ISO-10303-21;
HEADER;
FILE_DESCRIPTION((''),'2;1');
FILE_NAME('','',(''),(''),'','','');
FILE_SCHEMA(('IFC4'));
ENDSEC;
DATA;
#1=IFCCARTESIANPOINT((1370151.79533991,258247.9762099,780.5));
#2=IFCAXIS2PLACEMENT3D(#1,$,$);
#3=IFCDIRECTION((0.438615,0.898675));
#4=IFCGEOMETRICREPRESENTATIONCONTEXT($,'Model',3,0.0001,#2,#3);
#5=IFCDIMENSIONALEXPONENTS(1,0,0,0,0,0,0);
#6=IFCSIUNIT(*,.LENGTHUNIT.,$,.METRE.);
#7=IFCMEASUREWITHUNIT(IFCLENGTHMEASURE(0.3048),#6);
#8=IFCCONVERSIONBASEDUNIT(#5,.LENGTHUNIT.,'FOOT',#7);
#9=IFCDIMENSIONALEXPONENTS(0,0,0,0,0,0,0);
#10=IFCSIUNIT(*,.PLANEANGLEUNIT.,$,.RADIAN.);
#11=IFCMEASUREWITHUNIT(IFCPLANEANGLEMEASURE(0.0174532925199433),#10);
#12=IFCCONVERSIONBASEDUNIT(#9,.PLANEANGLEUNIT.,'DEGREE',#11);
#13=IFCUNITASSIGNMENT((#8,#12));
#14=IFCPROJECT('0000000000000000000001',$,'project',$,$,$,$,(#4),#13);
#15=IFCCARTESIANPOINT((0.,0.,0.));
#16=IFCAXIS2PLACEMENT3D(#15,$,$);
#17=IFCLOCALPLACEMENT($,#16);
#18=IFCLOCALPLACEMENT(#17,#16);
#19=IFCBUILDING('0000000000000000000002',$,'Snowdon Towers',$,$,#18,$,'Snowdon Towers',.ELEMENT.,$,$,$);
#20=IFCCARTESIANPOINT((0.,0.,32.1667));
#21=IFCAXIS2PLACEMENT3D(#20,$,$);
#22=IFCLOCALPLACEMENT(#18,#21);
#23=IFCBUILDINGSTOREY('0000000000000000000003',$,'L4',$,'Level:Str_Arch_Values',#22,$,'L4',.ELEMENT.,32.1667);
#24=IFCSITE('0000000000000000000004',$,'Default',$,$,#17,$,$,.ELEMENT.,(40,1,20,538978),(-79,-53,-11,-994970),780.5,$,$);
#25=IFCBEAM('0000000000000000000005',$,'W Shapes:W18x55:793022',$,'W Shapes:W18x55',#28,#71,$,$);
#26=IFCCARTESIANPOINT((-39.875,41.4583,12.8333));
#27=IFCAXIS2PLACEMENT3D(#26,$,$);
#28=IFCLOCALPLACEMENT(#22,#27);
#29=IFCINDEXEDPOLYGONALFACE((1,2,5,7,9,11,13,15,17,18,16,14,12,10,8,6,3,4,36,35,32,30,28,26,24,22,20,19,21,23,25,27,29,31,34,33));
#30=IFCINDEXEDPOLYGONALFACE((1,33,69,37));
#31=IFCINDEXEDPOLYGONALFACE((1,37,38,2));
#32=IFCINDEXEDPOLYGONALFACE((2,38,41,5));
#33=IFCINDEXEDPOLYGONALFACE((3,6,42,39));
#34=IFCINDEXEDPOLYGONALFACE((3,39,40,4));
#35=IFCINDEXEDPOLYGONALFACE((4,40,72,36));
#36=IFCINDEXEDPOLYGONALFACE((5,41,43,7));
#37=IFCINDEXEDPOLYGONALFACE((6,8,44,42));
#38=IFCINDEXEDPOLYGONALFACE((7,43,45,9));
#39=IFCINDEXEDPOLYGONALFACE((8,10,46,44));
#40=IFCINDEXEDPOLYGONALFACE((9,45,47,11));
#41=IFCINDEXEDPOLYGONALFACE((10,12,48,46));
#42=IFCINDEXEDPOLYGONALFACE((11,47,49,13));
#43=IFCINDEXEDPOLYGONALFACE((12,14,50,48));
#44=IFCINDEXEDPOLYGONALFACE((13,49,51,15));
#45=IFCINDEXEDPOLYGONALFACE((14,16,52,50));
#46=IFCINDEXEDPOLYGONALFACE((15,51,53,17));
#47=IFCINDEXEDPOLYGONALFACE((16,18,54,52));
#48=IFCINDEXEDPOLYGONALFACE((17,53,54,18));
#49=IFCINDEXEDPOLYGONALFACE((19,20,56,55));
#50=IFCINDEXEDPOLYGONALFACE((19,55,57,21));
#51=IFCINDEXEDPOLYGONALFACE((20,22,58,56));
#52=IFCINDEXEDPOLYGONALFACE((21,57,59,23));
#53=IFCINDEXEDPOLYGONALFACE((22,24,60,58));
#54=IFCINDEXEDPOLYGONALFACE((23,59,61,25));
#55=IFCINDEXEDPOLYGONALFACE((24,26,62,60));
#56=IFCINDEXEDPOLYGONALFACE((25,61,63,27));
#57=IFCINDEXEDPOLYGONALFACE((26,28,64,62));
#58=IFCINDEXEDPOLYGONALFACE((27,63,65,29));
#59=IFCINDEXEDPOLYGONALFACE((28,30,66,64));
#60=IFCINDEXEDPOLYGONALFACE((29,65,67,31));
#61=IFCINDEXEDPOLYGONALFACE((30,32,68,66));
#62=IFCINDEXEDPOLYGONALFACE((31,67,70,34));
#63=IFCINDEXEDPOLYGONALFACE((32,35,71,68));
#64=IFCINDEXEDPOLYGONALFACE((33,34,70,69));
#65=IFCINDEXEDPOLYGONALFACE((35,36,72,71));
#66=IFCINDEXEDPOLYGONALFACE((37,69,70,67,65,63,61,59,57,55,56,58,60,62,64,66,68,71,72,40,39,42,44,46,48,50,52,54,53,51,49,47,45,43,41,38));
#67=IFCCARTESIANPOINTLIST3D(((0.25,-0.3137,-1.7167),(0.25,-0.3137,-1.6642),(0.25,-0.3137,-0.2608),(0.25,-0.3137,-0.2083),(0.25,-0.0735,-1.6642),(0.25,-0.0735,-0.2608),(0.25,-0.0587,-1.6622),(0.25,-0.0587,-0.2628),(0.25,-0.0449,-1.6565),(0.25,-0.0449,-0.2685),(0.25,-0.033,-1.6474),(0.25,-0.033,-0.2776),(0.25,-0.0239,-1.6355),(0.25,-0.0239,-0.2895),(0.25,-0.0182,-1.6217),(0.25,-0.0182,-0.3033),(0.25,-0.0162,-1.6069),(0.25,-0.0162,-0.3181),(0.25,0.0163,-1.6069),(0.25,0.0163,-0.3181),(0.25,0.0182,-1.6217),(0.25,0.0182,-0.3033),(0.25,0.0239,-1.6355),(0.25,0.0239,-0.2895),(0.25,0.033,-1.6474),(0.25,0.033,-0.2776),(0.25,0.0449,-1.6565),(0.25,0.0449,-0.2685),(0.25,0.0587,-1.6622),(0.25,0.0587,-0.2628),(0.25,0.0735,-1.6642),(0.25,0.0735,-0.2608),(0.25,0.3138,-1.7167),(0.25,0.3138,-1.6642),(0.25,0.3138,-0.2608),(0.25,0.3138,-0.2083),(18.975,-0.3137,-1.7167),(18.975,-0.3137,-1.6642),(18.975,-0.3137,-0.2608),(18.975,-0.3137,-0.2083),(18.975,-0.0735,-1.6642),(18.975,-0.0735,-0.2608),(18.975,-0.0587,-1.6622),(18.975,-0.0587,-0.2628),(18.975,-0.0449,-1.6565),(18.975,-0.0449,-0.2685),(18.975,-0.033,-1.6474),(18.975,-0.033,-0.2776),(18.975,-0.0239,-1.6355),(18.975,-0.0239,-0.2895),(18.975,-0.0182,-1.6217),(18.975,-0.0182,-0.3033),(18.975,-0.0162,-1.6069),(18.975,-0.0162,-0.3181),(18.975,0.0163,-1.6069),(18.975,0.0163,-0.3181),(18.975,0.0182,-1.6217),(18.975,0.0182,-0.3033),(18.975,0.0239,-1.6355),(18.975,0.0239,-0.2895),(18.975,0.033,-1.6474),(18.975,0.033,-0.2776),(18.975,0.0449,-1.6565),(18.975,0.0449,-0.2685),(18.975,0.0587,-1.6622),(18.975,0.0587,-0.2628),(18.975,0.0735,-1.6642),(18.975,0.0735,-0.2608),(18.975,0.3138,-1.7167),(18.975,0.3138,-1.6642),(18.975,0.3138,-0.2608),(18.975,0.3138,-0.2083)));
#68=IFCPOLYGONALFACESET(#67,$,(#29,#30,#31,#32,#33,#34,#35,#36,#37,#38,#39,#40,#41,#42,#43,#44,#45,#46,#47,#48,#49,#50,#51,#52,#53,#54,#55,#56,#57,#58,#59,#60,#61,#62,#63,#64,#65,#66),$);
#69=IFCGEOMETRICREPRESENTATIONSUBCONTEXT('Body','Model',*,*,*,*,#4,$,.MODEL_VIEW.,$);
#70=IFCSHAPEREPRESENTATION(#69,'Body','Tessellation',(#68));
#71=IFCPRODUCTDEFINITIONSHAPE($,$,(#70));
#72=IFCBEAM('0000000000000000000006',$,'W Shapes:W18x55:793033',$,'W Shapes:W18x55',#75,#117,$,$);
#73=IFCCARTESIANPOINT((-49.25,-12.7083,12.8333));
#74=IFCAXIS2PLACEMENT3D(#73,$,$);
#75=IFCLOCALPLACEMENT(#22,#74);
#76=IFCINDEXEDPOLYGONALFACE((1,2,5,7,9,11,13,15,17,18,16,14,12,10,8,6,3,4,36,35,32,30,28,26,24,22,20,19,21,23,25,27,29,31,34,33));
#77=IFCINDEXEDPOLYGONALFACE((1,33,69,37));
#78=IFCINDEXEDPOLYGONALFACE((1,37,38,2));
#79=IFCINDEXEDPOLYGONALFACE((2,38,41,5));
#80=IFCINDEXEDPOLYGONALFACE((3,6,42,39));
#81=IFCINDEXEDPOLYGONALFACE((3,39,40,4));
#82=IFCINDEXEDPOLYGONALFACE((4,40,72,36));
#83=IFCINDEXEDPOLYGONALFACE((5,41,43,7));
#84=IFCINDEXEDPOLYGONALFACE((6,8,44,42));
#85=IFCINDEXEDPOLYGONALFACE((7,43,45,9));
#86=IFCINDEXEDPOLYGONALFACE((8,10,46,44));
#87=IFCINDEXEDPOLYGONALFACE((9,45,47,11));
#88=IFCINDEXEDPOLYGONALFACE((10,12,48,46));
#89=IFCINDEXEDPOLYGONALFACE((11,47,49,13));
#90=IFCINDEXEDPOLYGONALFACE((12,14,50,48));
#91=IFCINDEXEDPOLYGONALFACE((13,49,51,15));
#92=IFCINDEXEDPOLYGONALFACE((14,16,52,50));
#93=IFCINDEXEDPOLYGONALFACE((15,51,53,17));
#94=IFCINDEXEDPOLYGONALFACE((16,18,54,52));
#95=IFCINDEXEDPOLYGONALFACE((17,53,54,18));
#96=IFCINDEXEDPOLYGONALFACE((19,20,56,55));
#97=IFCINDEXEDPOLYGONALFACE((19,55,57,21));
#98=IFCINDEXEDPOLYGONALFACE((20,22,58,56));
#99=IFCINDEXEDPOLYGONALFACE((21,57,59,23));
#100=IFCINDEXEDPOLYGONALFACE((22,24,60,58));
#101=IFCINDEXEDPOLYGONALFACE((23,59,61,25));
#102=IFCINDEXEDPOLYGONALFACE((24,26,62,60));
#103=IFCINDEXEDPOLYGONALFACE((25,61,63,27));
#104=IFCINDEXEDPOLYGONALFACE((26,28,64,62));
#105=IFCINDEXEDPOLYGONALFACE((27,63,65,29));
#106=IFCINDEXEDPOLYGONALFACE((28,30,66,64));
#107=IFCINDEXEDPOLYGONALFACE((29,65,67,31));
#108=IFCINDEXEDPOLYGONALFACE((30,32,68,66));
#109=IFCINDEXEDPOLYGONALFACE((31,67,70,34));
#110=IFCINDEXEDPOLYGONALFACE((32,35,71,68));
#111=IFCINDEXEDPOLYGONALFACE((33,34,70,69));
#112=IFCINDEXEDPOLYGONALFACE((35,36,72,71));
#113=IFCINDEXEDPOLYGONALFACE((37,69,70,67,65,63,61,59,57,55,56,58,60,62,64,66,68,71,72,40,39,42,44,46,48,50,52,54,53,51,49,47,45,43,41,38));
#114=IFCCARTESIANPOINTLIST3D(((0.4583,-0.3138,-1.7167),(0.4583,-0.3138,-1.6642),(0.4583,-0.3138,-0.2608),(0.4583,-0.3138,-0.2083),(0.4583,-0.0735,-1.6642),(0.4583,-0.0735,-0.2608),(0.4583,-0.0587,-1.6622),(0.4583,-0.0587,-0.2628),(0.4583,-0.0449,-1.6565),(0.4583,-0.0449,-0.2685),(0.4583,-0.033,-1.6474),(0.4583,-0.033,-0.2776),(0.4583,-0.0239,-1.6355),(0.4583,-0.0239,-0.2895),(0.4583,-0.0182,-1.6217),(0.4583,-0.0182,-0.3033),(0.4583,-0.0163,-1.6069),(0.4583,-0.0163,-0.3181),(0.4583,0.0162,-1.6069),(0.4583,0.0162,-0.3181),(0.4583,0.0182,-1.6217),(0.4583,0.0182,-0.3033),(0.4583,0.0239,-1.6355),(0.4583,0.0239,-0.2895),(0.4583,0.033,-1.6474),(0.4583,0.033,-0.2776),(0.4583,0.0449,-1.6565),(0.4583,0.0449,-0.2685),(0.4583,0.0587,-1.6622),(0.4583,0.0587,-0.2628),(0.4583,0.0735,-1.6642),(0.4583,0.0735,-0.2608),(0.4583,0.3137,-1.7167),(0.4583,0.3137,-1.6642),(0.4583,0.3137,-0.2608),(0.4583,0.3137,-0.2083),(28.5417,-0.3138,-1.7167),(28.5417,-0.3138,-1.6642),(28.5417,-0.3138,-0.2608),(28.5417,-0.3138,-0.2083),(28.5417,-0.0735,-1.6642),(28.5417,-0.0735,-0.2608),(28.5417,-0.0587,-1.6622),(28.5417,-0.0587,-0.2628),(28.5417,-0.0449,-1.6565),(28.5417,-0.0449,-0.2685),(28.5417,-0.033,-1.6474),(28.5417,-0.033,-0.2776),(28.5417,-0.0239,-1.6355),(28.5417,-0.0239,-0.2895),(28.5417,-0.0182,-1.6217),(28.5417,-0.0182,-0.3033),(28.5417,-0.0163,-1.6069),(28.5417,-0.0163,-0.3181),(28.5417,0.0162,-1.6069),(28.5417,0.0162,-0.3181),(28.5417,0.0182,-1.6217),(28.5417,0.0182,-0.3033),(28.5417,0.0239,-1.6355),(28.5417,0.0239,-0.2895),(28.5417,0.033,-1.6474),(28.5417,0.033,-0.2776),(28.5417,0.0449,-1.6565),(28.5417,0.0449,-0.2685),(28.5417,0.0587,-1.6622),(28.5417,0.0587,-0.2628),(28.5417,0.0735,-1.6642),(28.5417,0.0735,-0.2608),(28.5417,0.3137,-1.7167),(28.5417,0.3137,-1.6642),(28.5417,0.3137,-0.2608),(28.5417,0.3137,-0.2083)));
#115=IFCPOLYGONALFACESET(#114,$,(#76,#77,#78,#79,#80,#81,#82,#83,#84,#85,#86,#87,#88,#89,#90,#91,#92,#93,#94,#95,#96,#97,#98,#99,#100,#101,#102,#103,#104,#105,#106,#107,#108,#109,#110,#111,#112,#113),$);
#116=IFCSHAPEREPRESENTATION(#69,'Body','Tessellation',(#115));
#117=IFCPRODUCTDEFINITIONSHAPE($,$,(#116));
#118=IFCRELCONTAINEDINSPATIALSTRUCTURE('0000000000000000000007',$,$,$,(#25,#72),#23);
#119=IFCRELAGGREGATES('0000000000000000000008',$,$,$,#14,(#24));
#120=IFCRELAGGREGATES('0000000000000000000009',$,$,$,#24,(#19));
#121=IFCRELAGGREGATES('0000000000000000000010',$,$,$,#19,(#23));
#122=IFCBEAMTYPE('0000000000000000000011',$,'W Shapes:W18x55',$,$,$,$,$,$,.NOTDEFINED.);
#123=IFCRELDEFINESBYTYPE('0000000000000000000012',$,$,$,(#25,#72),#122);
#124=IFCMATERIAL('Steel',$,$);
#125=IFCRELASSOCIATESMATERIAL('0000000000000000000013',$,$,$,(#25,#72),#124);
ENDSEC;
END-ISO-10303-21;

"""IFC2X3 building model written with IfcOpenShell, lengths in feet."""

from ifc_helpers import new_model, entity, si_unit, converted_unit, direction, frame, frame_2d, origin, place, context, subcontext, project, spatial, i_section, extrude, material, type_object, element, save


model = new_model("IFC2X3")

# Units and contexts
model_context = context("Model", 3, precision=0.0001, world=frame((1370151.79533991, 258247.9762099, 780.5)), true_north=direction((0.438615, 0.898675)))
body_context = subcontext(model_context, "Body", "Model", "MODEL_VIEW")
ifc_project = project(units=[converted_unit("LENGTHUNIT", "FOOT", entity("IfcLengthMeasure", 0.3048), si_unit("LENGTHUNIT", "METRE"), dimensions=[1, 0, 0, 0, 0, 0, 0]), converted_unit("PLANEANGLEUNIT", "DEGREE", entity("IfcPlaneAngleMeasure", 0.0174532925199433), si_unit("PLANEANGLEUNIT", "RADIAN"), dimensions=[0, 0, 0, 0, 0, 0, 0])], contexts=[model_context])

# Site, building, storey
site_placement = place(None, origin())
site = spatial("IfcSite", under=ifc_project, at=site_placement, Name="Default", CompositionType="ELEMENT", RefLatitude=(40, 1, 20, 538978), RefLongitude=(-79, -53, -11, -994970), RefElevation=780.5)
building_placement = place(site_placement, origin())
building = spatial("IfcBuilding", under=site, at=building_placement, Name="Snowdon Towers", LongName="Snowdon Towers", CompositionType="ELEMENT")
storey_placement = place(building_placement, frame((0.0, 0.0, 32.1667)))
storey = spatial("IfcBuildingStorey", under=building, at=storey_placement, Name="L4", ObjectType="Level:Str_Arch_Values", LongName="L4", CompositionType="ELEMENT", Elevation=32.1667)

# Beams
ifc_material_1 = material(Name="Steel")
beam_type_1 = type_object("IfcBeamType", Name="W Shapes:W18x55", PredefinedType="NOTDEFINED")
beam_1_placement = place(storey_placement, frame((-39.875, 41.4583, 12.8333)))
element("IfcBeam", 1, at=beam_1_placement, inside=storey, type_object=beam_type_1, material=ifc_material_1, Name="W Shapes:W18x55:793022", ObjectType="W Shapes:W18x55", context=body_context, shape_type="SweptSolid", body=[
    extrude(i_section(OverallWidth=0.6275, OverallDepth=1.5083, WebThickness=0.0325, FlangeThickness=0.0525, FilletRadius=0.0573, at=frame_2d((0.0, 0.0), x_axis=(0.0, 1.0))), frame((0.25, 0.0, -0.9625), z_axis=(1.0, 0.0, 0.0), x_axis=(0.0, 0.0, -1.0)), (0.0, 0.0, 1.0), 18.725),
])
beam_2_placement = place(storey_placement, frame((-49.25, -12.7083, 12.8333)))
element("IfcBeam", 2, at=beam_2_placement, inside=storey, type_object=beam_type_1, material=ifc_material_1, Name="W Shapes:W18x55:793033", ObjectType="W Shapes:W18x55", context=body_context, shape_type="SweptSolid", body=[
    extrude(i_section(OverallWidth=0.6275, OverallDepth=1.5083, WebThickness=0.0325, FlangeThickness=0.0525, FilletRadius=0.0573, at=frame_2d((0.0, 0.0), x_axis=(0.0, 1.0))), frame((0.4583, 0.0, -0.9625), z_axis=(1.0, 0.0, 0.0), x_axis=(0.0, 0.0, -1.0)), (0.0, 0.0, 1.0), 28.0833),
])

save(model, "model.ifc")
